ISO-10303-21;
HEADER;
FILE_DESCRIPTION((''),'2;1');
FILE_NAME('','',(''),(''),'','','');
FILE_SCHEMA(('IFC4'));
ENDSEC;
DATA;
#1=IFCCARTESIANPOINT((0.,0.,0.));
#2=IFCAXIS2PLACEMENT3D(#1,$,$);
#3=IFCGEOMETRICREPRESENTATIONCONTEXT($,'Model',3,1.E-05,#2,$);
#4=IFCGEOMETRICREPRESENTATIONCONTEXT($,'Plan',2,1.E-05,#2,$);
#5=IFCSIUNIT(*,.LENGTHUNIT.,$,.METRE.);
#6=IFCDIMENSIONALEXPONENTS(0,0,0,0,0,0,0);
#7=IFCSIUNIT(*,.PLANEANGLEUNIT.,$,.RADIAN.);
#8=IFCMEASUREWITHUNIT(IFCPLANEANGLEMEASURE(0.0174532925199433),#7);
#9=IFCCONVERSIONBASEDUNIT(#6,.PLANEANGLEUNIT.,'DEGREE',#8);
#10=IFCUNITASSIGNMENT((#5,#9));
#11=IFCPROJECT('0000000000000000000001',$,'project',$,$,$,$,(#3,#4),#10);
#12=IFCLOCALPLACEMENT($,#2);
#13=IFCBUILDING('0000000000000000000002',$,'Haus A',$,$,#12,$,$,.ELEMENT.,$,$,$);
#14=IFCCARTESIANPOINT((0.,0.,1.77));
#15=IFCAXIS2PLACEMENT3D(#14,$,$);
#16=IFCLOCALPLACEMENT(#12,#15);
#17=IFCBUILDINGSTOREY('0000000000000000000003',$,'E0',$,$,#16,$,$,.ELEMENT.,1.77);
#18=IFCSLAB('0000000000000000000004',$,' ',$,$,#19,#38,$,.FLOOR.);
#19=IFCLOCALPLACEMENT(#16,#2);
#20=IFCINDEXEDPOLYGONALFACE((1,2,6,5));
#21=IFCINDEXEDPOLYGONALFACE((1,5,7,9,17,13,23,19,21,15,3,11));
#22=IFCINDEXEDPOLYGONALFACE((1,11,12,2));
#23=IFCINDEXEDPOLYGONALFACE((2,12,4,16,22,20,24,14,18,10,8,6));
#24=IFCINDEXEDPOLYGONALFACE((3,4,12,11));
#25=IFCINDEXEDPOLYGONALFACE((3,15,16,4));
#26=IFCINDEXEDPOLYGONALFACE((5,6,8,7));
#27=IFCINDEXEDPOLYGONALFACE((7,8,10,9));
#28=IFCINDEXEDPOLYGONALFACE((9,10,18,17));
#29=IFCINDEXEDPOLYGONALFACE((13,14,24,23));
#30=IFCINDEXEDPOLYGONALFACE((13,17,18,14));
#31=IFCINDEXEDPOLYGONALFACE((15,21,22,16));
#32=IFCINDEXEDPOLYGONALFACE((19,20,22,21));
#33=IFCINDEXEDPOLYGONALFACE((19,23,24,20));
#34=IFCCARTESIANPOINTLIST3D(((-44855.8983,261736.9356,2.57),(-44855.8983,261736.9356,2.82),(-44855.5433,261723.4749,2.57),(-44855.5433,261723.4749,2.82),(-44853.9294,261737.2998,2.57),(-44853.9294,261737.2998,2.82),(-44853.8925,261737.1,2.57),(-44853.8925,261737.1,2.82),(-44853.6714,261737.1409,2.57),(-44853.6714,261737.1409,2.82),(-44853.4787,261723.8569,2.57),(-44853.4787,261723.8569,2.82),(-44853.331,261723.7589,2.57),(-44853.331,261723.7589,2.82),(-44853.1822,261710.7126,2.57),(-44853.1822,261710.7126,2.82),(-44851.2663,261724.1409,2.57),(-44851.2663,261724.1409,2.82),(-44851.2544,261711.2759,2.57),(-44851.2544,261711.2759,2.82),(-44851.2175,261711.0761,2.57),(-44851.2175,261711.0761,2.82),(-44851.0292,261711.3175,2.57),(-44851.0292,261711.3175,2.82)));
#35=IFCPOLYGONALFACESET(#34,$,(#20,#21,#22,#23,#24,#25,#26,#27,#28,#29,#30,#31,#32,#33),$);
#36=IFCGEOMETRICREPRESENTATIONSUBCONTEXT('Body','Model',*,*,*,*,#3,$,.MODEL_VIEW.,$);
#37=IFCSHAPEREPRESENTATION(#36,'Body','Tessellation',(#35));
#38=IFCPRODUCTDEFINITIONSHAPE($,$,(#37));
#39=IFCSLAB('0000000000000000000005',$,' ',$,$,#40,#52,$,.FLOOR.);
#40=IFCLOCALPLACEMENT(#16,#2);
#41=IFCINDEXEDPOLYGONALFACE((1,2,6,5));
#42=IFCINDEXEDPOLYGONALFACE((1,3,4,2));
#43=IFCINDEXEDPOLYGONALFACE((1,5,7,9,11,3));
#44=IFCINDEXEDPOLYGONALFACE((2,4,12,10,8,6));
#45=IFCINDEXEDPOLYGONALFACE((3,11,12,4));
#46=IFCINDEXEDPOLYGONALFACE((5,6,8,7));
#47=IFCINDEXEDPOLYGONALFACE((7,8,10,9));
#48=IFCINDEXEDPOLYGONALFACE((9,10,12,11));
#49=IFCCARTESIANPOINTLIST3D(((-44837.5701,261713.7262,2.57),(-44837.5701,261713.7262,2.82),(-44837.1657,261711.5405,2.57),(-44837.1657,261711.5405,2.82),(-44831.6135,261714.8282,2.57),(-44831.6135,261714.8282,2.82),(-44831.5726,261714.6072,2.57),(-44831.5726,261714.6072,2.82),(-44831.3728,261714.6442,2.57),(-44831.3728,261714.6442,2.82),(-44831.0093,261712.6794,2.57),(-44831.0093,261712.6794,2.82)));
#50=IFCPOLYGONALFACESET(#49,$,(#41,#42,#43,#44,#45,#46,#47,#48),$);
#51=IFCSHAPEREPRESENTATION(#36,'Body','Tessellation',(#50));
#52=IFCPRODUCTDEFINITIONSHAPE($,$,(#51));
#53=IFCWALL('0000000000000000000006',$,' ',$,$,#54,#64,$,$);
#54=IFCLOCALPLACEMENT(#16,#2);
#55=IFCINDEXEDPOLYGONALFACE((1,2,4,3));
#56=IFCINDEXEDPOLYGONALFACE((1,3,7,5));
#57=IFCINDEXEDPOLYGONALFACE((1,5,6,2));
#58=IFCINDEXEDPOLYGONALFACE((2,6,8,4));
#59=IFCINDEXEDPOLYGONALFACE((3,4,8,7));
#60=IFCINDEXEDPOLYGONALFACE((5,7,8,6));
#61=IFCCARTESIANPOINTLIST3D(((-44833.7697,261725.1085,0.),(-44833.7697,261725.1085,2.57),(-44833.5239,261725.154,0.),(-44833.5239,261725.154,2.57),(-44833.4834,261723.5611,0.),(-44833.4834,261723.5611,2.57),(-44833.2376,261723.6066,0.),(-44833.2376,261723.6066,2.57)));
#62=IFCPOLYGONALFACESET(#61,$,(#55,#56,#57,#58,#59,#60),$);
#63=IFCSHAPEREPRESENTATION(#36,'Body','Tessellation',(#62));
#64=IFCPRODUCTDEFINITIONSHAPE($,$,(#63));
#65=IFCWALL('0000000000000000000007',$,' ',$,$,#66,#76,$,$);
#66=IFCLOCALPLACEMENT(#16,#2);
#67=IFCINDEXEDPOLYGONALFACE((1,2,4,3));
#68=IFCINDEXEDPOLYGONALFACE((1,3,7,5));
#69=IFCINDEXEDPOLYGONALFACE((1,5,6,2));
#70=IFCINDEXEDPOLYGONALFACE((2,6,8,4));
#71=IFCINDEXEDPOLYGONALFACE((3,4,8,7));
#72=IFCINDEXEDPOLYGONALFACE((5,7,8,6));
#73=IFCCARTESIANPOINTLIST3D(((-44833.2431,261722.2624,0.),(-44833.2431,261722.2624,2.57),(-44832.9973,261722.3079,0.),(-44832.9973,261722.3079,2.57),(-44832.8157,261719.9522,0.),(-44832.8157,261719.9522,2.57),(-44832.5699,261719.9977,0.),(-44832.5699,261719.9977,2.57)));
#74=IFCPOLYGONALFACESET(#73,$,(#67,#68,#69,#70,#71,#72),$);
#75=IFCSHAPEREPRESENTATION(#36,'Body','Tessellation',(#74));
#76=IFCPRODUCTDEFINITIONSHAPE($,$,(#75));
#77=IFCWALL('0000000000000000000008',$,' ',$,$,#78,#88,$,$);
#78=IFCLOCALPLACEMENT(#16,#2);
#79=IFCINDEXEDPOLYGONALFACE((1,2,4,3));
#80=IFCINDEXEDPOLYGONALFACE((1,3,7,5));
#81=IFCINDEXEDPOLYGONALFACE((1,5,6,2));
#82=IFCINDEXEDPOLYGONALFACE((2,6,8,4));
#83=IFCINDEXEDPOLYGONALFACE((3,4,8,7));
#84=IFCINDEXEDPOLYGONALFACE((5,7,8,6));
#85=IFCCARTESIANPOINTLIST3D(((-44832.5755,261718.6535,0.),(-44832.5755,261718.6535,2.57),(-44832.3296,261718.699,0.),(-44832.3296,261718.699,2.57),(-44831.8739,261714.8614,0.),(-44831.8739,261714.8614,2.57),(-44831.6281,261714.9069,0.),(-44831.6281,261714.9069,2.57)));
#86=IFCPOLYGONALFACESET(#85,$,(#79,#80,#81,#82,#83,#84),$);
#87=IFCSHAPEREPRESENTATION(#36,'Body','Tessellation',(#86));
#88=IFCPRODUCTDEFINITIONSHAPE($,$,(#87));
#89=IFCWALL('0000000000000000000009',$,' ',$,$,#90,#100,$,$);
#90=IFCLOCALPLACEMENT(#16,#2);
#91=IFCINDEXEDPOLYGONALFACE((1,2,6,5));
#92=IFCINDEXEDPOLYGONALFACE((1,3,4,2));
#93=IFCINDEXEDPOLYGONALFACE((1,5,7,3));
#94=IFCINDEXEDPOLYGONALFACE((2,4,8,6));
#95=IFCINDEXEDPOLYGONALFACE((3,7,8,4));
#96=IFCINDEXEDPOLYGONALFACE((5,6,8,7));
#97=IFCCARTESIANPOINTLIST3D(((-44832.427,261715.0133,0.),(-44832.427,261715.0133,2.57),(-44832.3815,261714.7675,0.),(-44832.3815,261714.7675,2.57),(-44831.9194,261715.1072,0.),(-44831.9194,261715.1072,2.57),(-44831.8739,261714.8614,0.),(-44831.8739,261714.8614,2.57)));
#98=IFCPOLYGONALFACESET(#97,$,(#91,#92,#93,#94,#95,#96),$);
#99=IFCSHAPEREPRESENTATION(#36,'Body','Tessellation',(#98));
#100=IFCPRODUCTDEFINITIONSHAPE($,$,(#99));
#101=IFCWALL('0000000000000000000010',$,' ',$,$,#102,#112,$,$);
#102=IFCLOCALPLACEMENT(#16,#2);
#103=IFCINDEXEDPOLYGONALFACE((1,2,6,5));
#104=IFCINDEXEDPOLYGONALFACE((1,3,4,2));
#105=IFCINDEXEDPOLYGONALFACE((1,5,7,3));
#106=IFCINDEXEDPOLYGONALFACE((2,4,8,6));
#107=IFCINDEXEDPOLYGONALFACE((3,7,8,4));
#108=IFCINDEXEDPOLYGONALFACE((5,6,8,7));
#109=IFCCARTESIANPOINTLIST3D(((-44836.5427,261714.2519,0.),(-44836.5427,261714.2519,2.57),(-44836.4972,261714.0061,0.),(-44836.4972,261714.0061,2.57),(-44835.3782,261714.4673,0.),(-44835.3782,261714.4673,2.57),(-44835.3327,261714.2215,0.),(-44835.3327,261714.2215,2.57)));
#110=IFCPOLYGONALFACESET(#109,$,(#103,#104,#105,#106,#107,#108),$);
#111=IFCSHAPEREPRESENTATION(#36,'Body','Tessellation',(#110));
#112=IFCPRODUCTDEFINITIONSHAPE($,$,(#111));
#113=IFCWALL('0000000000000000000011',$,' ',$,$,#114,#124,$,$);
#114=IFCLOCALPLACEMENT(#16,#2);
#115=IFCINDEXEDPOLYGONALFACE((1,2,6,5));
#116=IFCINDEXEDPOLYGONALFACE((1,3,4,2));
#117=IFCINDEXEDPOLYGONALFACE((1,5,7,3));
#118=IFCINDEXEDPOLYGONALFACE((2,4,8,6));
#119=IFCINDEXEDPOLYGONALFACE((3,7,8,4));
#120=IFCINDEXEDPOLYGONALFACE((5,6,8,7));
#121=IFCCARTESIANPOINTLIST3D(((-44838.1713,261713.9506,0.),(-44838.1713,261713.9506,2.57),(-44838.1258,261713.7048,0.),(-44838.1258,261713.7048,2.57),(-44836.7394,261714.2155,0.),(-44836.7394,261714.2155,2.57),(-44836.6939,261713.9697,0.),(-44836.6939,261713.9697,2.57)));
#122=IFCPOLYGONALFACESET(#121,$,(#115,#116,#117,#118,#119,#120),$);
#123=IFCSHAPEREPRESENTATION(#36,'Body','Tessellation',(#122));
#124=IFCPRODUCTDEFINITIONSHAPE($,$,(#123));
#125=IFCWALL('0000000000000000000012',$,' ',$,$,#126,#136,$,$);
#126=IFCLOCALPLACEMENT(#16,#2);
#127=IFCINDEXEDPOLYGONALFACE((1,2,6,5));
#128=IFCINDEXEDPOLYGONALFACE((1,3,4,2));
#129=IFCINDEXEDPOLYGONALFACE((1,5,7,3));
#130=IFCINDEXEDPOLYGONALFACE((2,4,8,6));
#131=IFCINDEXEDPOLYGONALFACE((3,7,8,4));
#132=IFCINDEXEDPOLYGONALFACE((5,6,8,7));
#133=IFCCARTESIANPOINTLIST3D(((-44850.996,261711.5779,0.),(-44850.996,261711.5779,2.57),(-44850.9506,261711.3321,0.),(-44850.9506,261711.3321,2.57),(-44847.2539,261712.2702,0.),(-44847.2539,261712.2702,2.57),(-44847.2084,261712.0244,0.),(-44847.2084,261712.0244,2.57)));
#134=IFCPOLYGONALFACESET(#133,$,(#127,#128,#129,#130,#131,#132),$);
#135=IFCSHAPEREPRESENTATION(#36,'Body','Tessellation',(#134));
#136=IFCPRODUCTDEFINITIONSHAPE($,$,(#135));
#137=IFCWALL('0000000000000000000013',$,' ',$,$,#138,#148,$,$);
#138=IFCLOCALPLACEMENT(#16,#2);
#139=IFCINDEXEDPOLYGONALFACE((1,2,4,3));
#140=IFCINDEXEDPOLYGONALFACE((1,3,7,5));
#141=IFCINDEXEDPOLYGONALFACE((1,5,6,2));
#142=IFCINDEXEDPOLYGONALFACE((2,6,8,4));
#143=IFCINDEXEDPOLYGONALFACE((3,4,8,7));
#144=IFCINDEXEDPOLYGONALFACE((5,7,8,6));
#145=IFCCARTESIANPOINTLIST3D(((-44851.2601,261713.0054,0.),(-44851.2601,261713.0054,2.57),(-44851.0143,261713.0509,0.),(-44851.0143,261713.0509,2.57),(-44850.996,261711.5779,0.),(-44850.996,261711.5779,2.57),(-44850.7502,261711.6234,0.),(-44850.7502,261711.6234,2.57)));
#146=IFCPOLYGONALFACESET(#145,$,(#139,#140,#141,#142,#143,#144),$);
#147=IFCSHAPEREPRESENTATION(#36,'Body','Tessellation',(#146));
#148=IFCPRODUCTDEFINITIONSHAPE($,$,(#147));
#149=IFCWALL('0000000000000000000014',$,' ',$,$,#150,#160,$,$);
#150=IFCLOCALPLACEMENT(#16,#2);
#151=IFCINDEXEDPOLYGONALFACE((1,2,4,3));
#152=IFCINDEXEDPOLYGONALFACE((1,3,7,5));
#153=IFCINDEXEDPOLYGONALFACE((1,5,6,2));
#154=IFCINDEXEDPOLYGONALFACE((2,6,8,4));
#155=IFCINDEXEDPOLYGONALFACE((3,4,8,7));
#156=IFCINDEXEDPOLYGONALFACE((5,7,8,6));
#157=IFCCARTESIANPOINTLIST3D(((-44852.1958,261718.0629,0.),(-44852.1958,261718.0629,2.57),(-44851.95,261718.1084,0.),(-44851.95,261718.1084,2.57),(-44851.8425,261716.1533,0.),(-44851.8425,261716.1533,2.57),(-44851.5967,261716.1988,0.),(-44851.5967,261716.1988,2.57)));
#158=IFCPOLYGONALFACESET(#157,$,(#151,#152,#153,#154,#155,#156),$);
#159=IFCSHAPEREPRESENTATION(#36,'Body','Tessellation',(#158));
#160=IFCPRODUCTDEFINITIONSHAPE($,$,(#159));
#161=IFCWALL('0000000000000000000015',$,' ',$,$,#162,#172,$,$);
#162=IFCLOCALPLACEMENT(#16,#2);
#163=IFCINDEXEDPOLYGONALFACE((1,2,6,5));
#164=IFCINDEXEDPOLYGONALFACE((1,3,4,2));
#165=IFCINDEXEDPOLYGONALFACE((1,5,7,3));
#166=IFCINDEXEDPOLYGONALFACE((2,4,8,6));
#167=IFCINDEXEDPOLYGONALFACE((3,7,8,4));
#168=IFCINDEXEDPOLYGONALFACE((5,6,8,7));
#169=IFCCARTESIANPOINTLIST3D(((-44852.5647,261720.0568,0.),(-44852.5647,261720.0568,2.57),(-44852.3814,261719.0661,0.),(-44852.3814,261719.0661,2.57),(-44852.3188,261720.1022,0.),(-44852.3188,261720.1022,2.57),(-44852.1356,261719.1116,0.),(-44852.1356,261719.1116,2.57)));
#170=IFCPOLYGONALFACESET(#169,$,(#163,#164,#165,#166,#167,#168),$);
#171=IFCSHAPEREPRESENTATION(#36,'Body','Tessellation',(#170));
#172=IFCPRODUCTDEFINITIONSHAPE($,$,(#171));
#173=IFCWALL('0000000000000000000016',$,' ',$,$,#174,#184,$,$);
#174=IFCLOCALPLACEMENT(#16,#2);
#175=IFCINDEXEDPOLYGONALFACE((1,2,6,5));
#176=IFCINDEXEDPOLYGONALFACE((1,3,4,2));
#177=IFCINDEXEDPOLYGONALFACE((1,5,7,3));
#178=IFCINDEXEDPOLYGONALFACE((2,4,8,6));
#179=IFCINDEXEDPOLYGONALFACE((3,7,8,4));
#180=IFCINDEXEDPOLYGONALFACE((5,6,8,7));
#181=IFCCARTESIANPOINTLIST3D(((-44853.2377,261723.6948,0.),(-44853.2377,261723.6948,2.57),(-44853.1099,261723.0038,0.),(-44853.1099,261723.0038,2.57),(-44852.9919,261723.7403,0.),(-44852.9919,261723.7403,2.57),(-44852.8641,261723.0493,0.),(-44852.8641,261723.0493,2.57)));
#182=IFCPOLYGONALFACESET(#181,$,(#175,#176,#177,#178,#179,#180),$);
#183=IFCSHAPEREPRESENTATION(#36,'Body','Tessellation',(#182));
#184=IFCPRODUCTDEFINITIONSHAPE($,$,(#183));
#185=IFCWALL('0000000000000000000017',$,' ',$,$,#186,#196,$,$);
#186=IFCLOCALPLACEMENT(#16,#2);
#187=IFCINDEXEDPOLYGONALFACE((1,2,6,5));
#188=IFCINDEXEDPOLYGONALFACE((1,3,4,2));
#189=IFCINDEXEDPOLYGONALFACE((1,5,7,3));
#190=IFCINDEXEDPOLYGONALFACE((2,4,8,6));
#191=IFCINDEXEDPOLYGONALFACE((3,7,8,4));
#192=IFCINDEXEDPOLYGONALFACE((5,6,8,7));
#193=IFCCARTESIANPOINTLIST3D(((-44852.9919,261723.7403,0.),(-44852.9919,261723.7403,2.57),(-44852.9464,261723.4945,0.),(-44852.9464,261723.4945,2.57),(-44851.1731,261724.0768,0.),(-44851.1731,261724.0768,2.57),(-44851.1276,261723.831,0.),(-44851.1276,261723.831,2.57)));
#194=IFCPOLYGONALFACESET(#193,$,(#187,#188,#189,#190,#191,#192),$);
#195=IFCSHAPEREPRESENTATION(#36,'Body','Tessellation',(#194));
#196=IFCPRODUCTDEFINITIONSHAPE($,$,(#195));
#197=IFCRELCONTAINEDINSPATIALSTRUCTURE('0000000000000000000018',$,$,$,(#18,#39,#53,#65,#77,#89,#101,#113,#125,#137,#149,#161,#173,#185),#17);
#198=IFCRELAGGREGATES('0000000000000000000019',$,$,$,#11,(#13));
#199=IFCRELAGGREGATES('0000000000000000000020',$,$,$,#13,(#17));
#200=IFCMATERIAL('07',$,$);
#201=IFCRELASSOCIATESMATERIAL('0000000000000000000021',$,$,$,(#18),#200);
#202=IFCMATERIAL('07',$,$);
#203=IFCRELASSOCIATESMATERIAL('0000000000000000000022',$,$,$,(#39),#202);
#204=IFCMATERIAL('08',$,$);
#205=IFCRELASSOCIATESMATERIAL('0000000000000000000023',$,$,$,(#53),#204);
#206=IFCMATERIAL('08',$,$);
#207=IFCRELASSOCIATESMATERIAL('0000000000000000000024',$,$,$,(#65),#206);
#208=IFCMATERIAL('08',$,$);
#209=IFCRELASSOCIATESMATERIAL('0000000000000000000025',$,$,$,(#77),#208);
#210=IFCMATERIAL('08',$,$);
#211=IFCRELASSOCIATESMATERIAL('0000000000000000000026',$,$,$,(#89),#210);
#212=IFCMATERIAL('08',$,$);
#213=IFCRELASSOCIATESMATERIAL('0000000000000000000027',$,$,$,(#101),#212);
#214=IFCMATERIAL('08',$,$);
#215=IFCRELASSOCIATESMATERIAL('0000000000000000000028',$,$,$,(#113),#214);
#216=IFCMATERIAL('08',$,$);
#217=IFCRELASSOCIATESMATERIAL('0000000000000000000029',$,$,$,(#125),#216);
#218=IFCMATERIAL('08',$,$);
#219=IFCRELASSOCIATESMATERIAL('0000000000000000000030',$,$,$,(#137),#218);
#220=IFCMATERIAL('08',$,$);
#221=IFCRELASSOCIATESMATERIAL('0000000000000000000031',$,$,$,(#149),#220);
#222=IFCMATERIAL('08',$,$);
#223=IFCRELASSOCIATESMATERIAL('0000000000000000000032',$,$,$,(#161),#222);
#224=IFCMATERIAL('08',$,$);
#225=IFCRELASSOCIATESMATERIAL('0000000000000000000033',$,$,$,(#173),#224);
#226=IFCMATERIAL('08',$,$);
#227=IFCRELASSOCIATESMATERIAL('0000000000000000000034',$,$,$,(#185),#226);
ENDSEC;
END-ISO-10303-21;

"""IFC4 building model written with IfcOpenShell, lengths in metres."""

from ifc_helpers import new_model, entity, si_unit, converted_unit, frame, frame_2d, origin, origin_with_axes, place, context, subcontext, project, spatial, polyline, rectangle, outline, extrude, material, element, save


model = new_model("IFC4")

# Units and contexts
model_context = context("Model", 3, precision=1e-05, world=origin())
plan_context = context("Plan", 2, precision=1e-05, world=origin())
body_context = subcontext(model_context, "Body", "Model", "MODEL_VIEW")
ifc_project = project(units=[si_unit("LENGTHUNIT", "METRE"), converted_unit("PLANEANGLEUNIT", "DEGREE", entity("IfcPlaneAngleMeasure", 0.0174532925199433), si_unit("PLANEANGLEUNIT", "RADIAN"), dimensions=[0, 0, 0, 0, 0, 0, 0])], contexts=[model_context, plan_context])

# Building, storey
building_placement = place(None, origin())
building = spatial("IfcBuilding", under=ifc_project, at=building_placement, Name="Haus A", CompositionType="ELEMENT")
storey_placement = place(building_placement, frame((0.0, 0.0, 1.77)))
storey = spatial("IfcBuildingStorey", under=building, at=storey_placement, Name="E0", CompositionType="ELEMENT", Elevation=1.77)

# Slabs
ifc_material_1 = material(Name="07")
slab_1_placement = place(storey_placement, frame((-44855.8983, 261710.7126, 2.57)))
element("IfcSlab", 1, at=slab_1_placement, inside=storey, material=ifc_material_1, Name=" ", PredefinedType="FLOOR", context=body_context, shape_type="SweptSolid", body=[
    extrude(outline(polyline([(2.4196, 13.1443), (0.355, 12.7623), (2.7161, 0.0), (4.6809, 0.3635), (4.6439, 0.5633), (4.8691, 0.605), (2.5674, 13.0463), (4.632, 13.4283), (2.2269, 26.4283), (2.0058, 26.3874), (1.9689, 26.5872), (0.0, 26.223), (2.4196, 13.1443)])), origin_with_axes(), (0.0, 0.0, 1.0), 0.25),
])
ifc_material_2 = material(Name="07")
slab_2_placement = place(storey_placement, frame((-44837.5701, 261711.5405, 2.57)))
element("IfcSlab", 2, at=slab_2_placement, inside=storey, material=ifc_material_2, Name=" ", PredefinedType="FLOOR", context=body_context, shape_type="SweptSolid", body=[
    extrude(outline(polyline([(0.0, 2.1858), (0.4044, 0.0), (6.5608, 1.139), (6.1973, 3.1037), (5.9975, 3.0667), (5.9566, 3.2878), (0.0, 2.1858)])), origin_with_axes(), (0.0, 0.0, 1.0), 0.25),
])

# Walls
ifc_material_3 = material(Name="08")
wall_1_placement = place(storey_placement, frame((-44833.2376, 261723.6066, 0.0), z_axis=(0.0, 0.0, 1.0), x_axis=(-0.18192, 0.983313, 0.0)))
element("IfcWall", 3, at=wall_1_placement, inside=storey, material=ifc_material_3, Name=" ", context=body_context, shape_type="SweptSolid", body=[
    extrude(rectangle(XDim=1.5737, YDim=0.25, at=frame_2d((0.7868, 0.125), x_axis=(1.0, 0.0))), origin_with_axes(), (0.0, 0.0, 1.0), 2.57),
])
ifc_material_4 = material(Name="08")
wall_2_placement = place(storey_placement, frame((-44832.5699, 261719.9977, 0.0), z_axis=(0.0, 0.0, 1.0), x_axis=(-0.18192, 0.983313, 0.0)))
element("IfcWall", 4, at=wall_2_placement, inside=storey, material=ifc_material_4, Name=" ", context=body_context, shape_type="SweptSolid", body=[
    extrude(rectangle(XDim=2.3494, YDim=0.25, at=frame_2d((1.1747, 0.125), x_axis=(1.0, 0.0))), origin_with_axes(), (0.0, 0.0, 1.0), 2.57),
])
ifc_material_5 = material(Name="08")
wall_3_placement = place(storey_placement, frame((-44831.6281, 261714.9069, 0.0), z_axis=(0.0, 0.0, 1.0), x_axis=(-0.18192, 0.983313, 0.0)))
element("IfcWall", 5, at=wall_3_placement, inside=storey, material=ifc_material_5, Name=" ", context=body_context, shape_type="SweptSolid", body=[
    extrude(rectangle(XDim=3.8564, YDim=0.25, at=frame_2d((1.9282, 0.125), x_axis=(1.0, 0.0))), origin_with_axes(), (0.0, 0.0, 1.0), 2.57),
])
ifc_material_6 = material(Name="08")
wall_4_placement = place(storey_placement, frame((-44832.3815, 261714.7675, 0.0), z_axis=(0.0, 0.0, 1.0), x_axis=(0.983313, 0.18192, 0.0)))
element("IfcWall", 6, at=wall_4_placement, inside=storey, material=ifc_material_6, Name=" ", context=body_context, shape_type="SweptSolid", body=[
    extrude(rectangle(XDim=0.5162, YDim=0.25, at=frame_2d((0.2581, 0.125), x_axis=(1.0, 0.0))), origin_with_axes(), (0.0, 0.0, 1.0), 2.57),
])
ifc_material_7 = material(Name="08")
wall_5_placement = place(storey_placement, frame((-44836.4972, 261714.0061, 0.0), z_axis=(0.0, 0.0, 1.0), x_axis=(0.983313, 0.18192, 0.0)))
element("IfcWall", 7, at=wall_5_placement, inside=storey, material=ifc_material_7, Name=" ", context=body_context, shape_type="SweptSolid", body=[
    extrude(rectangle(XDim=1.1842, YDim=0.25, at=frame_2d((0.5921, 0.125), x_axis=(1.0, 0.0))), origin_with_axes(), (0.0, 0.0, 1.0), 2.57),
])
ifc_material_8 = material(Name="08")
wall_6_placement = place(storey_placement, frame((-44838.1258, 261713.7048, 0.0), z_axis=(0.0, 0.0, 1.0), x_axis=(0.983313, 0.18192, 0.0)))
element("IfcWall", 8, at=wall_6_placement, inside=storey, material=ifc_material_8, Name=" ", context=body_context, shape_type="SweptSolid", body=[
    extrude(rectangle(XDim=1.4562, YDim=0.25, at=frame_2d((0.7281, 0.125), x_axis=(1.0, 0.0))), origin_with_axes(), (0.0, 0.0, 1.0), 2.57),
])
ifc_material_9 = material(Name="08")
wall_7_placement = place(storey_placement, frame((-44850.9506, 261711.3321, 0.0), z_axis=(0.0, 0.0, 1.0), x_axis=(0.983313, 0.18192, 0.0)))
element("IfcWall", 9, at=wall_7_placement, inside=storey, material=ifc_material_9, Name=" ", context=body_context, shape_type="SweptSolid", body=[
    extrude(rectangle(XDim=3.8056, YDim=0.25, at=frame_2d((1.9028, 0.125), x_axis=(1.0, 0.0))), origin_with_axes(), (0.0, 0.0, 1.0), 2.57),
])
ifc_material_10 = material(Name="08")
wall_8_placement = place(storey_placement, frame((-44851.2601, 261713.0054, 0.0), z_axis=(0.0, 0.0, 1.0), x_axis=(0.18192, -0.983313, 0.0)))
element("IfcWall", 10, at=wall_8_placement, inside=storey, material=ifc_material_10, Name=" ", context=body_context, shape_type="SweptSolid", body=[
    extrude(rectangle(XDim=1.4517, YDim=0.25, at=frame_2d((0.7259, 0.125), x_axis=(1.0, 0.0))), origin_with_axes(), (0.0, 0.0, 1.0), 2.57),
])
ifc_material_11 = material(Name="08")
wall_9_placement = place(storey_placement, frame((-44852.1958, 261718.0629, 0.0), z_axis=(0.0, 0.0, 1.0), x_axis=(0.18192, -0.983313, 0.0)))
element("IfcWall", 11, at=wall_9_placement, inside=storey, material=ifc_material_11, Name=" ", context=body_context, shape_type="SweptSolid", body=[
    extrude(rectangle(XDim=1.942, YDim=0.25, at=frame_2d((0.971, 0.125), x_axis=(1.0, 0.0))), origin_with_axes(), (0.0, 0.0, 1.0), 2.57),
])
ifc_material_12 = material(Name="08")
wall_10_placement = place(storey_placement, frame((-44852.5647, 261720.0568, 0.0), z_axis=(0.0, 0.0, 1.0), x_axis=(0.18192, -0.983313, 0.0)))
element("IfcWall", 12, at=wall_10_placement, inside=storey, material=ifc_material_12, Name=" ", context=body_context, shape_type="SweptSolid", body=[
    extrude(rectangle(XDim=1.0075, YDim=0.25, at=frame_2d((0.5037, 0.125), x_axis=(1.0, 0.0))), origin_with_axes(), (0.0, 0.0, 1.0), 2.57),
])
ifc_material_13 = material(Name="08")
wall_11_placement = place(storey_placement, frame((-44853.2377, 261723.6948, 0.0), z_axis=(0.0, 0.0, 1.0), x_axis=(0.18192, -0.983313, 0.0)))
element("IfcWall", 13, at=wall_11_placement, inside=storey, material=ifc_material_13, Name=" ", context=body_context, shape_type="SweptSolid", body=[
    extrude(rectangle(XDim=0.7027, YDim=0.25, at=frame_2d((0.3514, 0.125), x_axis=(1.0, 0.0))), origin_with_axes(), (0.0, 0.0, 1.0), 2.57),
])
ifc_material_14 = material(Name="08")
wall_12_placement = place(storey_placement, frame((-44851.1731, 261724.0768, 0.0), z_axis=(0.0, 0.0, 1.0), x_axis=(-0.983313, -0.18192, 0.0)))
element("IfcWall", 14, at=wall_12_placement, inside=storey, material=ifc_material_14, Name=" ", context=body_context, shape_type="SweptSolid", body=[
    extrude(rectangle(XDim=1.8497, YDim=0.25, at=frame_2d((0.9248, 0.125), x_axis=(1.0, 0.0))), origin_with_axes(), (0.0, 0.0, 1.0), 2.57),
])

save(model, "model.ifc")
